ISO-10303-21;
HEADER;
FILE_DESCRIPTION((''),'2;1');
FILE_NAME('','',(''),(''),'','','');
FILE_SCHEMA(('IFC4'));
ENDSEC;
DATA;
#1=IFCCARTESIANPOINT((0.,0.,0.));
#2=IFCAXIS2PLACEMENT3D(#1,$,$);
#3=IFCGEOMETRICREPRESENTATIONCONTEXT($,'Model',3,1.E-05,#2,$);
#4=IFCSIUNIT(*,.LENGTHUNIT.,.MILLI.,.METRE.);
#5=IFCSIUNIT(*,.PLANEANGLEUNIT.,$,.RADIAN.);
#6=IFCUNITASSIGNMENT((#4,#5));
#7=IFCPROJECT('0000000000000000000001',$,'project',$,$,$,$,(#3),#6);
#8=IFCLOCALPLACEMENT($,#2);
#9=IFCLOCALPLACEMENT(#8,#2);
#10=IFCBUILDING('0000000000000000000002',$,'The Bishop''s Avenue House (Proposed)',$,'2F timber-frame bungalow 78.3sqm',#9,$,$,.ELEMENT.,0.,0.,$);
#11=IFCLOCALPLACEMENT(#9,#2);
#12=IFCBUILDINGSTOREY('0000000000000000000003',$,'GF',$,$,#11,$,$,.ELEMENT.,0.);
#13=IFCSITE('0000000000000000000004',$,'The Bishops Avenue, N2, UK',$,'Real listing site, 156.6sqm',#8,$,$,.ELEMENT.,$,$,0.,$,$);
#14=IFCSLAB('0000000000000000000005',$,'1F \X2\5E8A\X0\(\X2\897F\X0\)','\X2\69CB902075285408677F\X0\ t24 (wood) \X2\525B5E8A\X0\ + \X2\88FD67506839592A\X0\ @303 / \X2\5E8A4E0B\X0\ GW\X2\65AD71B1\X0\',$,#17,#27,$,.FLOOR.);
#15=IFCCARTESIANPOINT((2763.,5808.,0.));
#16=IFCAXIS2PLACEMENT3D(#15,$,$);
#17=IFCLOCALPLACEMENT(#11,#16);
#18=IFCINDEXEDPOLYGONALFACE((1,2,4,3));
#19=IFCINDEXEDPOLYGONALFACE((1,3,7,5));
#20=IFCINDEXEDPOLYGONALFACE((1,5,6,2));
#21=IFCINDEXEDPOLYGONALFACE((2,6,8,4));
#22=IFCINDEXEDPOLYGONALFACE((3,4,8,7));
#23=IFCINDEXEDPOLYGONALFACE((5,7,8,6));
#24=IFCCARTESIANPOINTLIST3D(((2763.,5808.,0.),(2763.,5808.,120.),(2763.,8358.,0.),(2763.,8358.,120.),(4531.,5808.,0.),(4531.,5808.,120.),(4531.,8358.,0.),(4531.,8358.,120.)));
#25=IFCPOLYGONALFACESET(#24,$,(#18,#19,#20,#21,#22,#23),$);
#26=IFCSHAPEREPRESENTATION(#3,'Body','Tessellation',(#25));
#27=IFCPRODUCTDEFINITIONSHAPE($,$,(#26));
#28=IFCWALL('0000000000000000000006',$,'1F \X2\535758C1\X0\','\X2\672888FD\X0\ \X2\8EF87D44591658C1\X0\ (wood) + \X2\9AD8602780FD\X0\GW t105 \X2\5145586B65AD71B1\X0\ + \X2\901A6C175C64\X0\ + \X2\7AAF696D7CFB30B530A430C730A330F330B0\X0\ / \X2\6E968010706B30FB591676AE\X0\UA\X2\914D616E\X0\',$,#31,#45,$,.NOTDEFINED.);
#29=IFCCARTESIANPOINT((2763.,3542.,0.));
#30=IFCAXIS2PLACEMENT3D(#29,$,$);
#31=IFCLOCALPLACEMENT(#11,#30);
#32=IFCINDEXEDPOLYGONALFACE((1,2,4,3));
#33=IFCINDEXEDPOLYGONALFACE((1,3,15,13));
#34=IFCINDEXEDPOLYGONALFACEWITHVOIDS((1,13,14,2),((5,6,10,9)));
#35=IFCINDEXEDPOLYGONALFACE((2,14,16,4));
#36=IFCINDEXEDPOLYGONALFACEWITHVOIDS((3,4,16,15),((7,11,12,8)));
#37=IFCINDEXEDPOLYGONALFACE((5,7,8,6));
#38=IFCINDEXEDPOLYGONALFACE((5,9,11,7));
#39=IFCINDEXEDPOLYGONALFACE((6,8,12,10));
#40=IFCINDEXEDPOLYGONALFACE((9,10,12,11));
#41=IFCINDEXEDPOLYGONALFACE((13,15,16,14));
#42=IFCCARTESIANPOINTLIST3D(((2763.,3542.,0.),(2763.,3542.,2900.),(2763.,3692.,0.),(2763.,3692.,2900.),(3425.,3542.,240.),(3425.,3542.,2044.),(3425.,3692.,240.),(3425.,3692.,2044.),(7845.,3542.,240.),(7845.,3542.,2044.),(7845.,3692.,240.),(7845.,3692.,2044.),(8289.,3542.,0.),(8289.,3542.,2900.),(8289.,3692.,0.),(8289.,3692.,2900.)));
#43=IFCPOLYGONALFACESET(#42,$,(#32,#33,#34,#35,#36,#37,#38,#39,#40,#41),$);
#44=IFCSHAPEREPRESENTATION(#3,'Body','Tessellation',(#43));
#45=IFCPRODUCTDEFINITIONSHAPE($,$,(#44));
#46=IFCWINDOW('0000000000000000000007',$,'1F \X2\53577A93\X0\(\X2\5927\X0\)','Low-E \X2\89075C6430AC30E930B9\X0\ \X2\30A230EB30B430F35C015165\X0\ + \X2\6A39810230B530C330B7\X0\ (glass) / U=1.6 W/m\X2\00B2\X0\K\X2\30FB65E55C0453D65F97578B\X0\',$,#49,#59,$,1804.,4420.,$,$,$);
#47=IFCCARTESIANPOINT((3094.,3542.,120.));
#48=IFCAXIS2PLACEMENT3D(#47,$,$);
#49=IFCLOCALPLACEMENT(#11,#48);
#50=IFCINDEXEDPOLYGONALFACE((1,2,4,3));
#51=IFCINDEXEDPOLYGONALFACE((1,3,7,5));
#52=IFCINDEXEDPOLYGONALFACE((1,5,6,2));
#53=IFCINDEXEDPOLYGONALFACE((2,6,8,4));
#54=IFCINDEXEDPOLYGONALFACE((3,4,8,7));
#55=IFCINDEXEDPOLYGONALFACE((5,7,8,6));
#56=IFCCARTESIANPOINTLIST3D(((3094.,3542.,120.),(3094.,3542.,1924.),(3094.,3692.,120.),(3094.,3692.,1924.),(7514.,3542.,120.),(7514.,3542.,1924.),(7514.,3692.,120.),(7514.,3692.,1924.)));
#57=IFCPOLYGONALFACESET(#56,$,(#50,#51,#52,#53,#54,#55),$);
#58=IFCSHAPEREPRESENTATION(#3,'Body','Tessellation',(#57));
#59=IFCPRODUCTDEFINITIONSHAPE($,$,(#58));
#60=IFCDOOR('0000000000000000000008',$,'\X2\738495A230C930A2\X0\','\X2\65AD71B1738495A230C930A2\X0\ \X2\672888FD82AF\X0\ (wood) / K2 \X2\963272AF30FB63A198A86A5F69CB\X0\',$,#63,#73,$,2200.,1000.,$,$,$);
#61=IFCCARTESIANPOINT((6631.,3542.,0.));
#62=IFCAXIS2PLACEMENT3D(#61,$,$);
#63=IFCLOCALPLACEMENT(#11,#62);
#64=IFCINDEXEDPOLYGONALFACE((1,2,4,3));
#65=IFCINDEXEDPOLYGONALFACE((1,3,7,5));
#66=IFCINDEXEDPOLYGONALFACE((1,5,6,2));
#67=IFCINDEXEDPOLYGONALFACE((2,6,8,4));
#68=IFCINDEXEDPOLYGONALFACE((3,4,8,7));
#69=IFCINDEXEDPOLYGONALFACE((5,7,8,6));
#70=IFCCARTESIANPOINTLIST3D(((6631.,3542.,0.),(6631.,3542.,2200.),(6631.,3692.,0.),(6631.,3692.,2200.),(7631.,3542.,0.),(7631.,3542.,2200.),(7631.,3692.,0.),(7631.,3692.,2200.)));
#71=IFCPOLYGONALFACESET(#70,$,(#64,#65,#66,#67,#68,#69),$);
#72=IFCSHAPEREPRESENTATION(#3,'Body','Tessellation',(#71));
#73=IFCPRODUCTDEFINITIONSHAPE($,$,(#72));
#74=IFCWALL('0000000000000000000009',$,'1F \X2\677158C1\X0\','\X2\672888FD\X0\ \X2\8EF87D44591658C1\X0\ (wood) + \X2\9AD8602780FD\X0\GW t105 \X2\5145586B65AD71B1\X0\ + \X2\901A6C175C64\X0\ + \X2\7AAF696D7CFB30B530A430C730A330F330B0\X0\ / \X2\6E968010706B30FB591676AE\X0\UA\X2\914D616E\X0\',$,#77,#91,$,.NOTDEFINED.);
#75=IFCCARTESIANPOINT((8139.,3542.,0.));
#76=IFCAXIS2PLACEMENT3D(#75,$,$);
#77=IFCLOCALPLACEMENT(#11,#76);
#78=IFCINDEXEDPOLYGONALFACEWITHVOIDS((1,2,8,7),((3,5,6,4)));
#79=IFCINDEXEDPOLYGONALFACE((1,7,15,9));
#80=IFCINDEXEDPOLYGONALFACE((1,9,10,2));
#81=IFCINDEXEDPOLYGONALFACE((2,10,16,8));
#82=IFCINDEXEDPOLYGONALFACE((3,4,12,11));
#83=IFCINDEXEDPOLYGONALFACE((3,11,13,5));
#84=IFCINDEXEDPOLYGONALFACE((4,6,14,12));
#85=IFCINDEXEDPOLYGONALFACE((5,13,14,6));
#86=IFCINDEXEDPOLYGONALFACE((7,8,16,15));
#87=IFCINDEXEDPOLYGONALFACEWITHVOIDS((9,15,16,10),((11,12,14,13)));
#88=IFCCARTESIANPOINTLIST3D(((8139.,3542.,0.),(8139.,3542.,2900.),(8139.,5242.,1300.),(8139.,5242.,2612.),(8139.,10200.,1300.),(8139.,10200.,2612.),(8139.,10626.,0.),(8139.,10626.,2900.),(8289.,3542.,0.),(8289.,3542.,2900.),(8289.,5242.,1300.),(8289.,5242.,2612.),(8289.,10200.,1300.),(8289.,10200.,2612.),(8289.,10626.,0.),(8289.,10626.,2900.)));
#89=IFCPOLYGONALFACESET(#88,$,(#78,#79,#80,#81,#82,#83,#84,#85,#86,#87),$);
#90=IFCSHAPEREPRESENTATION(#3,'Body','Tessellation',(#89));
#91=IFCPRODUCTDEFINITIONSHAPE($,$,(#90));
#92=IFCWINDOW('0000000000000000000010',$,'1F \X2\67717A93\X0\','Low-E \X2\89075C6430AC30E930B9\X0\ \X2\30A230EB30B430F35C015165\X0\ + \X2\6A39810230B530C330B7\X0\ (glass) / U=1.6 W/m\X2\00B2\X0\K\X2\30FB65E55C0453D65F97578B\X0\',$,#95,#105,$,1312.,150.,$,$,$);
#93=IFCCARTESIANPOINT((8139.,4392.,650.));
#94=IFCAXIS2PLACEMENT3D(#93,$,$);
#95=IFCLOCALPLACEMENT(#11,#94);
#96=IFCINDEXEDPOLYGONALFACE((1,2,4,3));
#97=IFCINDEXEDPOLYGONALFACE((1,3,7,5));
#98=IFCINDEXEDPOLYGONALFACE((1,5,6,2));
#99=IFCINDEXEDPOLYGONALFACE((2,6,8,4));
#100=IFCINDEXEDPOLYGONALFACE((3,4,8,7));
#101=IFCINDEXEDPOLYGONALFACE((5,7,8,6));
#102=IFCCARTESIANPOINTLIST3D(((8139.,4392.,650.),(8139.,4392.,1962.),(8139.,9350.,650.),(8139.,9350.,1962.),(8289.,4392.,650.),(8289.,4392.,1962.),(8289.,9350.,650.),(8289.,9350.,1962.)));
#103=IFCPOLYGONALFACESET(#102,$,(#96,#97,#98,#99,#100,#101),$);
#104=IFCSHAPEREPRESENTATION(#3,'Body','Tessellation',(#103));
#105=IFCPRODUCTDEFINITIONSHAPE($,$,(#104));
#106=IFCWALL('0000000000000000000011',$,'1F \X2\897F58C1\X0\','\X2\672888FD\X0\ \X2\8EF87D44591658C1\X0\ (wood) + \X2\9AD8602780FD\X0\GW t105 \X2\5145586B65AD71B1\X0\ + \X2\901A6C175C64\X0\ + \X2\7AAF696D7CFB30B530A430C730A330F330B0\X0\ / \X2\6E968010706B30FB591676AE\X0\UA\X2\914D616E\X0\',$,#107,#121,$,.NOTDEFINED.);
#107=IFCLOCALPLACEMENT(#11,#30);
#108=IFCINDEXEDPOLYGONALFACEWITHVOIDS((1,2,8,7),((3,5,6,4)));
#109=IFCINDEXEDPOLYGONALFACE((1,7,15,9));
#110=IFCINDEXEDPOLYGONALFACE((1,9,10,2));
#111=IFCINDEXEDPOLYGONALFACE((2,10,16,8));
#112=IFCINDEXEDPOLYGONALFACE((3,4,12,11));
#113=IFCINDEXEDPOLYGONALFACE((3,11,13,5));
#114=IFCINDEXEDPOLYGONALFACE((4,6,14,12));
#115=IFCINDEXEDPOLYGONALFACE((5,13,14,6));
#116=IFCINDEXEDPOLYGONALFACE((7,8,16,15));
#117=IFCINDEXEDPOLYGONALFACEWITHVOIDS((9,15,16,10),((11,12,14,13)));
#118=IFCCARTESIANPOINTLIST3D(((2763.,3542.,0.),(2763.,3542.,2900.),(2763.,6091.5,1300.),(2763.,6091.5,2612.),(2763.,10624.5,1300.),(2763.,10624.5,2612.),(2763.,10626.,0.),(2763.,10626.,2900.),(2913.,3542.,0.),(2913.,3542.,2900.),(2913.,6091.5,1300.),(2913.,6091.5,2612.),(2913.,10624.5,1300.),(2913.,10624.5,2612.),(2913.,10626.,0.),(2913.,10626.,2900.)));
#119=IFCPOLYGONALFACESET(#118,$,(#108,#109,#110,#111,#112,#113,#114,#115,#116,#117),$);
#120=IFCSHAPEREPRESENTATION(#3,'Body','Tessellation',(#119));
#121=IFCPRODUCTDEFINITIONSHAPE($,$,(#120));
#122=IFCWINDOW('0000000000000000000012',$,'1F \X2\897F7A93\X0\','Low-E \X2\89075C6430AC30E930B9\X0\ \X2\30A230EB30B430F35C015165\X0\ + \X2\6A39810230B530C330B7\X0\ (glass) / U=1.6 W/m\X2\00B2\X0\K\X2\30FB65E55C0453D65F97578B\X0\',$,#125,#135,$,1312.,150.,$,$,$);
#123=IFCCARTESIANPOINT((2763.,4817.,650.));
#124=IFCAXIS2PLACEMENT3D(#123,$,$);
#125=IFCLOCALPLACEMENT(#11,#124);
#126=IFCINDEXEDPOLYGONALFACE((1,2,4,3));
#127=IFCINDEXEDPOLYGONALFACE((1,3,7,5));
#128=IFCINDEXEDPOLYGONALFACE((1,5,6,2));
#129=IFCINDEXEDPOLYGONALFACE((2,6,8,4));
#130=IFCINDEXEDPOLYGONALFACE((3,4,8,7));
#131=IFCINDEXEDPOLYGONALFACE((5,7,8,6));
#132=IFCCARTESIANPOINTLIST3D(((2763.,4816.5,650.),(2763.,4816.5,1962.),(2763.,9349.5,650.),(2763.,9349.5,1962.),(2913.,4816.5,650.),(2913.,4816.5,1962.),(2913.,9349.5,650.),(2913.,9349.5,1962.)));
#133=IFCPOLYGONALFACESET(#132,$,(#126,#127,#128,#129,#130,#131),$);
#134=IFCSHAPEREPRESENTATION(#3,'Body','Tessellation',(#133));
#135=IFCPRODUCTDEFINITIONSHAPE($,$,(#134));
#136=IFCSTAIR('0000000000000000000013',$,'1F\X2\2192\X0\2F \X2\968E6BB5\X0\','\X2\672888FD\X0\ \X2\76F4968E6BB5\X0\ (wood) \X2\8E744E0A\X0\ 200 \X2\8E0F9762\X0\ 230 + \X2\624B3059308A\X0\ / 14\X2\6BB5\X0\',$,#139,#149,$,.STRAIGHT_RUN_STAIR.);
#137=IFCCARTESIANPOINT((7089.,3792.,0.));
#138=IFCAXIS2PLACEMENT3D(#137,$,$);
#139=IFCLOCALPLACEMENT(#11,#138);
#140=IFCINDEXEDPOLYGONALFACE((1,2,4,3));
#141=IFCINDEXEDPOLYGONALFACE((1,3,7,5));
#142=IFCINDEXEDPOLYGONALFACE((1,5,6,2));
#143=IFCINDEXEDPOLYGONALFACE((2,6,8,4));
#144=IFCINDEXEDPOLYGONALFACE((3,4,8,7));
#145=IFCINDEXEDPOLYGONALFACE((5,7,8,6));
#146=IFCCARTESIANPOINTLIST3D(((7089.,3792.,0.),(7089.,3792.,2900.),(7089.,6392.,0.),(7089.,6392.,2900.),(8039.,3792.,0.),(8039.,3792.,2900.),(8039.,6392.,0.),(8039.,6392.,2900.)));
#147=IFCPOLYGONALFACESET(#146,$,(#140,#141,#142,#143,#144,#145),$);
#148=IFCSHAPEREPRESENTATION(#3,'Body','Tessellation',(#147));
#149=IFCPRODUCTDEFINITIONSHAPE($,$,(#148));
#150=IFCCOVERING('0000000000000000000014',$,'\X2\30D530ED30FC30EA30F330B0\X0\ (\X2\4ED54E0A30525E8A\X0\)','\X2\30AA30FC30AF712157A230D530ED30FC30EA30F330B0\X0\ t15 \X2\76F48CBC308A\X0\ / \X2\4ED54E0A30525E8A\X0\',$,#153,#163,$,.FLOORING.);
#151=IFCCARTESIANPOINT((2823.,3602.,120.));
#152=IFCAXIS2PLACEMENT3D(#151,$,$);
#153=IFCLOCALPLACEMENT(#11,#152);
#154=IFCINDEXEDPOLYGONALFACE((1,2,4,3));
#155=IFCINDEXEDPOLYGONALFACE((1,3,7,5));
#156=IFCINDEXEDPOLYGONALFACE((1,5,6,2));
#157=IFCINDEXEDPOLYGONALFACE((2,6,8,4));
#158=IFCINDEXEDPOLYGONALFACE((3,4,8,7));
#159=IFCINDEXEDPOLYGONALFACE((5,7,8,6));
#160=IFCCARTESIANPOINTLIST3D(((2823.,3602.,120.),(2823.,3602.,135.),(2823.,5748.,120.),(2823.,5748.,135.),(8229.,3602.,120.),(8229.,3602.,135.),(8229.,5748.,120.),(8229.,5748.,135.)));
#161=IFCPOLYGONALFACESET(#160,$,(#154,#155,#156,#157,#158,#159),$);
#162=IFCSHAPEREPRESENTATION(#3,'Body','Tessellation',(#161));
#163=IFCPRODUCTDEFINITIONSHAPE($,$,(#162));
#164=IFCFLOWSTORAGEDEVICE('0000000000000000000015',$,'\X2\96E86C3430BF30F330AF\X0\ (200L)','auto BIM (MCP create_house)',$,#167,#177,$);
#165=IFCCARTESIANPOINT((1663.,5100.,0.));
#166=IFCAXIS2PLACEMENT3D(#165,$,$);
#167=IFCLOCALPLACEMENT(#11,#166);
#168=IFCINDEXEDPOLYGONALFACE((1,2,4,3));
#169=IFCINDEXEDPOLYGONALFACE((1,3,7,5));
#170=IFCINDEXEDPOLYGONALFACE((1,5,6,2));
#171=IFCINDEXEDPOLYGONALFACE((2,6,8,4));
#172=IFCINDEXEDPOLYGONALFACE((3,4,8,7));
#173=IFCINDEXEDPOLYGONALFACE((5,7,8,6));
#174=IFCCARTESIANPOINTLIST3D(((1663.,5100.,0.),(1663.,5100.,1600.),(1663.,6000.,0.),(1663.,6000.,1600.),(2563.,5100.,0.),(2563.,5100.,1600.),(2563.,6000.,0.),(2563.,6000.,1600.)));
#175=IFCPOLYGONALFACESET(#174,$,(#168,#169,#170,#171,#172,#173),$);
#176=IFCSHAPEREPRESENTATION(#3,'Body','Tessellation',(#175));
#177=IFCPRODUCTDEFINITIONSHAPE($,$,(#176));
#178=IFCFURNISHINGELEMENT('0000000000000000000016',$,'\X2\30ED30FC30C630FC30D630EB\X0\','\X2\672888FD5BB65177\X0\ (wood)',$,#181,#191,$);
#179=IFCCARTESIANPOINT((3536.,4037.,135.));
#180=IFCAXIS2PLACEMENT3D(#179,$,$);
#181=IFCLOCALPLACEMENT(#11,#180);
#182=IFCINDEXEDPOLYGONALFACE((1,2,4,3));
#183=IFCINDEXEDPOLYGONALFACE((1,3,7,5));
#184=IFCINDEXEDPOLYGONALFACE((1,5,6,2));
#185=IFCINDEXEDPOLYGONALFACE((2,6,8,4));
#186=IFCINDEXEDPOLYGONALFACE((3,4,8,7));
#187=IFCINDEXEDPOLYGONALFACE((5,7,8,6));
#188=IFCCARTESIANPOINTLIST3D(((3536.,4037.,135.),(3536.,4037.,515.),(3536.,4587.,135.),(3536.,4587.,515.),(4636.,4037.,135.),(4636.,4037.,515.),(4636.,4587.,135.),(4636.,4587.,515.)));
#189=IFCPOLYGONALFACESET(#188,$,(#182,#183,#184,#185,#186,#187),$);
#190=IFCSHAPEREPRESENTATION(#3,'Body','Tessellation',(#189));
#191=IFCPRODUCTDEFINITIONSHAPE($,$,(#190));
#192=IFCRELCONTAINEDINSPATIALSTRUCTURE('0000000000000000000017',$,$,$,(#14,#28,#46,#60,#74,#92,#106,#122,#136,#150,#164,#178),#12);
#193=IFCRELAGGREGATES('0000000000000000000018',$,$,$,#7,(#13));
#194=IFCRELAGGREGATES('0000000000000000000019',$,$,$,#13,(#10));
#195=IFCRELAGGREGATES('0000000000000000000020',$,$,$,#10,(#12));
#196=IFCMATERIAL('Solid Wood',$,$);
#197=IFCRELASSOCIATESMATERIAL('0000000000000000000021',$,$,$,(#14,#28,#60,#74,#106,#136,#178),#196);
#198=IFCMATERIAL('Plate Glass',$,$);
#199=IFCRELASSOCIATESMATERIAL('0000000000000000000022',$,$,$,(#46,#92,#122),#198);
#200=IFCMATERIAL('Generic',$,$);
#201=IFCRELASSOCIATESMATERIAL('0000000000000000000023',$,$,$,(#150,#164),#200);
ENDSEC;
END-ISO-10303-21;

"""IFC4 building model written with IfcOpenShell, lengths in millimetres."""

from ifc_helpers import new_model, si_unit, frame, frame_2d, origin, place, context, project, spatial, rectangle, extrude, material, element, fill, save


model = new_model("IFC4")

# Units and contexts
model_context = context("Model", 3, precision=1e-05, world=origin())
ifc_project = project(units=[si_unit("LENGTHUNIT", "METRE", prefix="MILLI"), si_unit("PLANEANGLEUNIT", "RADIAN")], contexts=[model_context])

# Site, building, storey
site_placement = place(None, origin())
site = spatial("IfcSite", under=ifc_project, at=site_placement, Name="The Bishops Avenue, N2, UK", ObjectType="Real listing site, 156.6sqm", CompositionType="ELEMENT", RefElevation=0.0)
building_placement = place(site_placement, origin())
building = spatial("IfcBuilding", under=site, at=building_placement, Name="The Bishop's Avenue House (Proposed)", ObjectType="2F timber-frame bungalow 78.3sqm", CompositionType="ELEMENT", ElevationOfRefHeight=0.0, ElevationOfTerrain=0.0)
storey_placement = place(building_placement, origin())
storey = spatial("IfcBuildingStorey", under=building, at=storey_placement, Name="GF", CompositionType="ELEMENT", Elevation=0.0)

# Slab
ifc_material_1 = material(Name="Solid Wood")
slab_1_placement = place(storey_placement, frame((2763.0, 5808.0, 0.0)))
element("IfcSlab", 1, at=slab_1_placement, inside=storey, material=ifc_material_1, Name="1F 床(西)", Description="構造用合板 t24 (wood) 剛床 + 製材根太 @303 / 床下 GW断熱", PredefinedType="FLOOR", context=model_context, shape_type="SweptSolid", body=[
    extrude(rectangle(XDim=1768.0, YDim=2550.0, at=frame_2d((884.0, 1275.0))), frame((2763.0, 5808.0, 0.0)), (0.0, 0.0, 1.0), 120.0),
])

# Wall, openings, window, door
wall_1_placement = place(storey_placement, frame((2763.0, 3542.0, 0.0)))
wall_1 = element("IfcWall", 2, at=wall_1_placement, inside=storey, material=ifc_material_1, Name="1F 南壁", Description="木製 軸組外壁 (wood) + 高性能GW t105 充填断熱 + 通気層 + 窯業系サイディング / 準耐火・外皮UA配慮", PredefinedType="NOTDEFINED", context=model_context, shape_type="SweptSolid", body=[
    extrude(rectangle(XDim=5526.0, YDim=150.0, at=frame_2d((2763.0, 75.0))), frame((2763.0, 3542.0, 0.0)), (0.0, 0.0, 1.0), 2900.0),
])
opening_1_placement = place(storey_placement, frame((3094.0, 3542.0, 120.0)))
opening_1 = element("IfcOpeningElement", 3, at=opening_1_placement, cuts=wall_1, PredefinedType="NOTDEFINED", context=model_context, shape_type="SweptSolid", body=[
    extrude(rectangle(XDim=4420.0, YDim=150.0, at=frame_2d((2210.0, 75.0))), frame((3094.0, 3542.0, 120.0)), (0.0, 0.0, 1.0), 1804.0),
])
opening_2_placement = place(storey_placement, frame((6631.0, 3542.0, 0.0)))
opening_2 = element("IfcOpeningElement", 4, at=opening_2_placement, cuts=wall_1, PredefinedType="NOTDEFINED", context=model_context, shape_type="SweptSolid", body=[
    extrude(rectangle(XDim=1000.0, YDim=150.0, at=frame_2d((500.0, 75.0))), frame((6631.0, 3542.0, 0.0)), (0.0, 0.0, 1.0), 2200.0),
])
ifc_material_2 = material(Name="Plate Glass")
window_1_placement = place(storey_placement, frame((3094.0, 3542.0, 120.0)))
window_1 = element("IfcWindow", 5, at=window_1_placement, inside=storey, material=ifc_material_2, Name="1F 南窓(大)", Description="Low-E 複層ガラス アルゴン封入 + 樹脂サッシ (glass) / U=1.6 W/m²K・日射取得型", OverallHeight=1804.0, OverallWidth=4420.0, context=model_context, shape_type="SweptSolid", body=[
    extrude(rectangle(XDim=4420.0, YDim=150.0, at=frame_2d((2210.0, 75.0))), frame((3094.0, 3542.0, 120.0)), (0.0, 0.0, 1.0), 1804.0),
])
fill(opening_1, window_1)
door_placement = place(storey_placement, frame((6631.0, 3542.0, 0.0)))
door = element("IfcDoor", 6, at=door_placement, inside=storey, material=ifc_material_1, Name="玄関ドア", Description="断熱玄関ドア 木製芯 (wood) / K2 防犯・採風機構", OverallHeight=2200.0, OverallWidth=1000.0, context=model_context, shape_type="SweptSolid", body=[
    extrude(rectangle(XDim=1000.0, YDim=150.0, at=frame_2d((500.0, 75.0))), frame((6631.0, 3542.0, 0.0)), (0.0, 0.0, 1.0), 2200.0),
])
fill(opening_2, door)

# Walls, openings, windows
wall_2_placement = place(storey_placement, frame((8139.0, 3542.0, 0.0)))
wall_2 = element("IfcWall", 7, at=wall_2_placement, inside=storey, material=ifc_material_1, Name="1F 東壁", Description="木製 軸組外壁 (wood) + 高性能GW t105 充填断熱 + 通気層 + 窯業系サイディング / 準耐火・外皮UA配慮", PredefinedType="NOTDEFINED", context=model_context, shape_type="SweptSolid", body=[
    extrude(rectangle(XDim=150.0, YDim=7084.0, at=frame_2d((75.0, 3542.0))), frame((8139.0, 3542.0, 0.0)), (0.0, 0.0, 1.0), 2900.0),
])
opening_3_placement = place(storey_placement, frame((8139.0, 4392.0, 650.0)))
opening_3 = element("IfcOpeningElement", 8, at=opening_3_placement, cuts=wall_2, PredefinedType="NOTDEFINED", context=model_context, shape_type="SweptSolid", body=[
    extrude(rectangle(XDim=150.0, YDim=4958.0, at=frame_2d((75.0, 2479.0))), frame((8139.0, 4392.0, 650.0)), (0.0, 0.0, 1.0), 1312.0),
])
window_2_placement = place(storey_placement, frame((8139.0, 4392.0, 650.0)))
window_2 = element("IfcWindow", 9, at=window_2_placement, inside=storey, material=ifc_material_2, Name="1F 東窓", Description="Low-E 複層ガラス アルゴン封入 + 樹脂サッシ (glass) / U=1.6 W/m²K・日射取得型", OverallHeight=1312.0, OverallWidth=150.0, context=model_context, shape_type="SweptSolid", body=[
    extrude(rectangle(XDim=150.0, YDim=4958.0, at=frame_2d((75.0, 2479.0))), frame((8139.0, 4392.0, 650.0)), (0.0, 0.0, 1.0), 1312.0),
])
fill(opening_3, window_2)
wall_3_placement = place(storey_placement, frame((2763.0, 3542.0, 0.0)))
wall_3 = element("IfcWall", 10, at=wall_3_placement, inside=storey, material=ifc_material_1, Name="1F 西壁", Description="木製 軸組外壁 (wood) + 高性能GW t105 充填断熱 + 通気層 + 窯業系サイディング / 準耐火・外皮UA配慮", PredefinedType="NOTDEFINED", context=model_context, shape_type="SweptSolid", body=[
    extrude(rectangle(XDim=150.0, YDim=7084.0, at=frame_2d((75.0, 3542.0))), frame((2763.0, 3542.0, 0.0)), (0.0, 0.0, 1.0), 2900.0),
])
opening_4_placement = place(storey_placement, frame((2763.0, 4817.0, 650.0)))
opening_4 = element("IfcOpeningElement", 11, at=opening_4_placement, cuts=wall_3, PredefinedType="NOTDEFINED", context=model_context, shape_type="SweptSolid", body=[
    extrude(rectangle(XDim=150.0, YDim=4533.0, at=frame_2d((75.0, 2266.0))), frame((2763.0, 4817.0, 650.0)), (0.0, 0.0, 1.0), 1312.0),
])
window_3_placement = place(storey_placement, frame((2763.0, 4817.0, 650.0)))
window_3 = element("IfcWindow", 12, at=window_3_placement, inside=storey, material=ifc_material_2, Name="1F 西窓", Description="Low-E 複層ガラス アルゴン封入 + 樹脂サッシ (glass) / U=1.6 W/m²K・日射取得型", OverallHeight=1312.0, OverallWidth=150.0, context=model_context, shape_type="SweptSolid", body=[
    extrude(rectangle(XDim=150.0, YDim=4533.0, at=frame_2d((75.0, 2266.0))), frame((2763.0, 4817.0, 650.0)), (0.0, 0.0, 1.0), 1312.0),
])
fill(opening_4, window_3)

# Stair
stair_placement = place(storey_placement, frame((7089.0, 3792.0, 0.0)))
element("IfcStair", 13, at=stair_placement, inside=storey, material=ifc_material_1, Name="1F→2F 階段", Description="木製 直階段 (wood) 蹴上 200 踏面 230 + 手すり / 14段", PredefinedType="STRAIGHT_RUN_STAIR", context=model_context, shape_type="SweptSolid", body=[
    extrude(rectangle(XDim=950.0, YDim=2600.0, at=frame_2d((475.0, 1300.0))), frame((7089.0, 3792.0, 0.0)), (0.0, 0.0, 1.0), 2900.0),
])

# Covering
ifc_material_3 = material(Name="Generic")
covering_placement = place(storey_placement, frame((2823.0, 3602.0, 120.0)))
element("IfcCovering", 14, at=covering_placement, inside=storey, material=ifc_material_3, Name="フローリング (仕上げ床)", Description="オーク無垢フローリング t15 直貼り / 仕上げ床", PredefinedType="FLOORING", context=model_context, shape_type="SweptSolid", body=[
    extrude(rectangle(XDim=5406.0, YDim=2146.0, at=frame_2d((2703.0, 1073.0))), frame((2823.0, 3602.0, 120.0)), (0.0, 0.0, 1.0), 15.0),
])

# Flow storage device
flow_storage_device_placement = place(storey_placement, frame((1663.0, 5100.0, 0.0)))
element("IfcFlowStorageDevice", 15, at=flow_storage_device_placement, inside=storey, material=ifc_material_3, Name="雨水タンク (200L)", Description="auto BIM (MCP create_house)", context=model_context, shape_type="SweptSolid", body=[
    extrude(rectangle(XDim=900.0, YDim=900.0, at=frame_2d((450.0, 450.0))), frame((1663.0, 5100.0, 0.0)), (0.0, 0.0, 1.0), 1600.0),
])

# Furnishing element
furnishing_1_placement = place(storey_placement, frame((3536.0, 4037.0, 135.0)))
element("IfcFurnishingElement", 16, at=furnishing_1_placement, inside=storey, material=ifc_material_1, Name="ローテーブル", Description="木製家具 (wood)", context=model_context, shape_type="SweptSolid", body=[
    extrude(rectangle(XDim=1100.0, YDim=550.0, at=frame_2d((550.0, 275.0))), frame((3536.0, 4037.0, 135.0)), (0.0, 0.0, 1.0), 380.0),
])

save(model, "model.ifc")
